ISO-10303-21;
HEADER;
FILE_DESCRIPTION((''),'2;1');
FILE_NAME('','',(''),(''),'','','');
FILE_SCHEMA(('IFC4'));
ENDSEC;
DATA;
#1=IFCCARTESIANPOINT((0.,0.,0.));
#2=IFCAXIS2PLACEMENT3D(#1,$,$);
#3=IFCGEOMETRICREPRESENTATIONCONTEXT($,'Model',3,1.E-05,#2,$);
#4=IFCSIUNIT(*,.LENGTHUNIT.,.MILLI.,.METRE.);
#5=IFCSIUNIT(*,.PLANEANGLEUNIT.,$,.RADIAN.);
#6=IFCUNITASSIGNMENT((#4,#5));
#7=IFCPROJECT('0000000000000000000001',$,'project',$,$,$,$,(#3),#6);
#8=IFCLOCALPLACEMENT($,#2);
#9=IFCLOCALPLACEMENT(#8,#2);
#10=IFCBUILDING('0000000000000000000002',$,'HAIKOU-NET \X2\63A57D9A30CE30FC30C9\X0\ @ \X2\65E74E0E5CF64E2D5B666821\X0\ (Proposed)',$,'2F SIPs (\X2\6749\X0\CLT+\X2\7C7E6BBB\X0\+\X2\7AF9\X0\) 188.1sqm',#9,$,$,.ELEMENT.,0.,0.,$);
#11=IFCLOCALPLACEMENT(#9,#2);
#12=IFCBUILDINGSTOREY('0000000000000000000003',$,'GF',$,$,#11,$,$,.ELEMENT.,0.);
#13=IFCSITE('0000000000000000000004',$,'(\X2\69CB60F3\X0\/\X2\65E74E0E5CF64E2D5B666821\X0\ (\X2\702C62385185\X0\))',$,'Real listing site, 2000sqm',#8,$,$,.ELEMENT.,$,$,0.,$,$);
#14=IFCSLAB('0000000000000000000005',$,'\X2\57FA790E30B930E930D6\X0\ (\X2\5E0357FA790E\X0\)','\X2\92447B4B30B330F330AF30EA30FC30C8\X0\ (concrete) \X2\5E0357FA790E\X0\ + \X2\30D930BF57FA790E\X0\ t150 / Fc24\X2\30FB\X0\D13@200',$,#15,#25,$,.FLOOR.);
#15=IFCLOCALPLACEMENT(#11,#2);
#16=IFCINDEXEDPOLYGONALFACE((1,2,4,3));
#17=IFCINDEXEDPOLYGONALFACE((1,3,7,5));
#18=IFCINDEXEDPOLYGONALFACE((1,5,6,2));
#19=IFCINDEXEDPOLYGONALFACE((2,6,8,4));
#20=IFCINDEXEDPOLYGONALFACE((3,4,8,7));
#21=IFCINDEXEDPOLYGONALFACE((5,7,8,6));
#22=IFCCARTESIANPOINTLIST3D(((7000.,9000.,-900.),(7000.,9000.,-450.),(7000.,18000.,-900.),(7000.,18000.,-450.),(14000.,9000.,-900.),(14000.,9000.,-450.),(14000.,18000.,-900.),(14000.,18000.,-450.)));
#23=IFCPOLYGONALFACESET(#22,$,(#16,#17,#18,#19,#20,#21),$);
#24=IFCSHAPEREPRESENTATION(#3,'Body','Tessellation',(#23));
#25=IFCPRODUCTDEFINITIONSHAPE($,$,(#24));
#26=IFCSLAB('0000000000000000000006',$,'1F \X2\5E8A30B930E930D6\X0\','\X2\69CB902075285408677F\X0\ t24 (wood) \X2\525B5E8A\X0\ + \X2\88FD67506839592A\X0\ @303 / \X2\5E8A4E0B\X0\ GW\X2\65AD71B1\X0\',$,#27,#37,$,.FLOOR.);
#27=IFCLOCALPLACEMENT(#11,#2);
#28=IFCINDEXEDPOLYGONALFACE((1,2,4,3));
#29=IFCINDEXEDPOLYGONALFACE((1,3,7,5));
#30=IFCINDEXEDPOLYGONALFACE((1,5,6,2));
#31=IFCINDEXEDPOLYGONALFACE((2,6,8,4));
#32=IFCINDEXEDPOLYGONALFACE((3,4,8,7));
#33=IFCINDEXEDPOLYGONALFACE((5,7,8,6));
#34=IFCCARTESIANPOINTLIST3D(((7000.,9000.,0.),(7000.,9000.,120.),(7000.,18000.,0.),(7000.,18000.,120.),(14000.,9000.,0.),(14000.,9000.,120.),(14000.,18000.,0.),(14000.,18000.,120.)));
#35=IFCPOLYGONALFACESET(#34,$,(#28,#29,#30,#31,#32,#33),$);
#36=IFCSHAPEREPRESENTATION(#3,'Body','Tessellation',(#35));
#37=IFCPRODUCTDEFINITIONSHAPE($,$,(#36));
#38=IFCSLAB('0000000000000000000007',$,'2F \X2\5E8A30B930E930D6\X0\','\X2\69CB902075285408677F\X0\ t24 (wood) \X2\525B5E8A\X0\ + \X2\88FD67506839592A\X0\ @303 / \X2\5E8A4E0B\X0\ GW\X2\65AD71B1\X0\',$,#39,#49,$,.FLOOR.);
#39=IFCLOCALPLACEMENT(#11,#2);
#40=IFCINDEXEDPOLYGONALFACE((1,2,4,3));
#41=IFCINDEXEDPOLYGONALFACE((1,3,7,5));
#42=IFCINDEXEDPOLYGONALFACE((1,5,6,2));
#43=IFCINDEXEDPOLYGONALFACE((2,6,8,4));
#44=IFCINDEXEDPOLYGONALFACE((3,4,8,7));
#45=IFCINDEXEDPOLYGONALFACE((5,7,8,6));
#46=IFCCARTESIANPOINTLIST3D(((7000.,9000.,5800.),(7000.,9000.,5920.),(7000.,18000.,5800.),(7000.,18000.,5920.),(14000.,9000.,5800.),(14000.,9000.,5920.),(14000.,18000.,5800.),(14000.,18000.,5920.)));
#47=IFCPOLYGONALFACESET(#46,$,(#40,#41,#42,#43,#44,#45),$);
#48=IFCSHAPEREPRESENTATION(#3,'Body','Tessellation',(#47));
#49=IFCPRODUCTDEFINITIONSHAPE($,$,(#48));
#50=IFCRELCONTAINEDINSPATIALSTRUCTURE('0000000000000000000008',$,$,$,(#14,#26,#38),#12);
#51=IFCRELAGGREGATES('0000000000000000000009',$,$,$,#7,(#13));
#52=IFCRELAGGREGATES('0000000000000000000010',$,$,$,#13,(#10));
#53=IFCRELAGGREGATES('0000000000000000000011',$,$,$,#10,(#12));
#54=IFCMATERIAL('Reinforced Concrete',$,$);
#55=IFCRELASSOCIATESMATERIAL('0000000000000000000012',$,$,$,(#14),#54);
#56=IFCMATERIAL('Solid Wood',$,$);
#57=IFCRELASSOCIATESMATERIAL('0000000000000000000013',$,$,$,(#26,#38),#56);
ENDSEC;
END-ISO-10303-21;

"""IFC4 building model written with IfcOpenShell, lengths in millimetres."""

from ifc_helpers import new_model, si_unit, frame, frame_2d, origin, place, context, project, spatial, rectangle, extrude, material, element, save


model = new_model("IFC4")

# Units and contexts
model_context = context("Model", 3, precision=1e-05, world=origin())
ifc_project = project(units=[si_unit("LENGTHUNIT", "METRE", prefix="MILLI"), si_unit("PLANEANGLEUNIT", "RADIAN")], contexts=[model_context])

# Site, building, storey
site_placement = place(None, origin())
site = spatial("IfcSite", under=ifc_project, at=site_placement, Name="(構想/旧与島中学校 (瀬戸内))", ObjectType="Real listing site, 2000sqm", CompositionType="ELEMENT", RefElevation=0.0)
building_placement = place(site_placement, origin())
building = spatial("IfcBuilding", under=site, at=building_placement, Name="HAIKOU-NET 接続ノード @ 旧与島中学校 (Proposed)", ObjectType="2F SIPs (杉CLT+籾殻+竹) 188.1sqm", CompositionType="ELEMENT", ElevationOfRefHeight=0.0, ElevationOfTerrain=0.0)
storey_placement = place(building_placement, origin())
storey = spatial("IfcBuildingStorey", under=building, at=storey_placement, Name="GF", CompositionType="ELEMENT", Elevation=0.0)

# Slabs
ifc_material_1 = material(Name="Reinforced Concrete")
slab_1_placement = place(storey_placement, frame((3500.0, 4500.0, -450.0)))
element("IfcSlab", 1, at=slab_1_placement, inside=storey, material=ifc_material_1, Name="基礎スラブ (布基礎)", Description="鉄筋コンクリート (concrete) 布基礎 + ベタ基礎 t150 / Fc24・D13@200", PredefinedType="FLOOR", context=model_context, shape_type="SweptSolid", body=[
    extrude(rectangle(XDim=7000.0, YDim=9000.0, at=frame_2d((3500.0, 4500.0))), frame((3500.0, 4500.0, -450.0)), (0.0, 0.0, 1.0), 450.0),
])
ifc_material_2 = material(Name="Solid Wood")
slab_2_placement = place(storey_placement, frame((3500.0, 4500.0, 0.0)))
element("IfcSlab", 2, at=slab_2_placement, inside=storey, material=ifc_material_2, Name="1F 床スラブ", Description="構造用合板 t24 (wood) 剛床 + 製材根太 @303 / 床下 GW断熱", PredefinedType="FLOOR", context=model_context, shape_type="SweptSolid", body=[
    extrude(rectangle(XDim=7000.0, YDim=9000.0, at=frame_2d((3500.0, 4500.0))), frame((3500.0, 4500.0, 0.0)), (0.0, 0.0, 1.0), 120.0),
])
slab_3_placement = place(storey_placement, frame((3500.0, 4500.0, 2900.0)))
element("IfcSlab", 3, at=slab_3_placement, inside=storey, material=ifc_material_2, Name="2F 床スラブ", Description="構造用合板 t24 (wood) 剛床 + 製材根太 @303 / 床下 GW断熱", PredefinedType="FLOOR", context=model_context, shape_type="SweptSolid", body=[
    extrude(rectangle(XDim=7000.0, YDim=9000.0, at=frame_2d((3500.0, 4500.0))), frame((3500.0, 4500.0, 2900.0)), (0.0, 0.0, 1.0), 120.0),
])

save(model, "model.ifc")
